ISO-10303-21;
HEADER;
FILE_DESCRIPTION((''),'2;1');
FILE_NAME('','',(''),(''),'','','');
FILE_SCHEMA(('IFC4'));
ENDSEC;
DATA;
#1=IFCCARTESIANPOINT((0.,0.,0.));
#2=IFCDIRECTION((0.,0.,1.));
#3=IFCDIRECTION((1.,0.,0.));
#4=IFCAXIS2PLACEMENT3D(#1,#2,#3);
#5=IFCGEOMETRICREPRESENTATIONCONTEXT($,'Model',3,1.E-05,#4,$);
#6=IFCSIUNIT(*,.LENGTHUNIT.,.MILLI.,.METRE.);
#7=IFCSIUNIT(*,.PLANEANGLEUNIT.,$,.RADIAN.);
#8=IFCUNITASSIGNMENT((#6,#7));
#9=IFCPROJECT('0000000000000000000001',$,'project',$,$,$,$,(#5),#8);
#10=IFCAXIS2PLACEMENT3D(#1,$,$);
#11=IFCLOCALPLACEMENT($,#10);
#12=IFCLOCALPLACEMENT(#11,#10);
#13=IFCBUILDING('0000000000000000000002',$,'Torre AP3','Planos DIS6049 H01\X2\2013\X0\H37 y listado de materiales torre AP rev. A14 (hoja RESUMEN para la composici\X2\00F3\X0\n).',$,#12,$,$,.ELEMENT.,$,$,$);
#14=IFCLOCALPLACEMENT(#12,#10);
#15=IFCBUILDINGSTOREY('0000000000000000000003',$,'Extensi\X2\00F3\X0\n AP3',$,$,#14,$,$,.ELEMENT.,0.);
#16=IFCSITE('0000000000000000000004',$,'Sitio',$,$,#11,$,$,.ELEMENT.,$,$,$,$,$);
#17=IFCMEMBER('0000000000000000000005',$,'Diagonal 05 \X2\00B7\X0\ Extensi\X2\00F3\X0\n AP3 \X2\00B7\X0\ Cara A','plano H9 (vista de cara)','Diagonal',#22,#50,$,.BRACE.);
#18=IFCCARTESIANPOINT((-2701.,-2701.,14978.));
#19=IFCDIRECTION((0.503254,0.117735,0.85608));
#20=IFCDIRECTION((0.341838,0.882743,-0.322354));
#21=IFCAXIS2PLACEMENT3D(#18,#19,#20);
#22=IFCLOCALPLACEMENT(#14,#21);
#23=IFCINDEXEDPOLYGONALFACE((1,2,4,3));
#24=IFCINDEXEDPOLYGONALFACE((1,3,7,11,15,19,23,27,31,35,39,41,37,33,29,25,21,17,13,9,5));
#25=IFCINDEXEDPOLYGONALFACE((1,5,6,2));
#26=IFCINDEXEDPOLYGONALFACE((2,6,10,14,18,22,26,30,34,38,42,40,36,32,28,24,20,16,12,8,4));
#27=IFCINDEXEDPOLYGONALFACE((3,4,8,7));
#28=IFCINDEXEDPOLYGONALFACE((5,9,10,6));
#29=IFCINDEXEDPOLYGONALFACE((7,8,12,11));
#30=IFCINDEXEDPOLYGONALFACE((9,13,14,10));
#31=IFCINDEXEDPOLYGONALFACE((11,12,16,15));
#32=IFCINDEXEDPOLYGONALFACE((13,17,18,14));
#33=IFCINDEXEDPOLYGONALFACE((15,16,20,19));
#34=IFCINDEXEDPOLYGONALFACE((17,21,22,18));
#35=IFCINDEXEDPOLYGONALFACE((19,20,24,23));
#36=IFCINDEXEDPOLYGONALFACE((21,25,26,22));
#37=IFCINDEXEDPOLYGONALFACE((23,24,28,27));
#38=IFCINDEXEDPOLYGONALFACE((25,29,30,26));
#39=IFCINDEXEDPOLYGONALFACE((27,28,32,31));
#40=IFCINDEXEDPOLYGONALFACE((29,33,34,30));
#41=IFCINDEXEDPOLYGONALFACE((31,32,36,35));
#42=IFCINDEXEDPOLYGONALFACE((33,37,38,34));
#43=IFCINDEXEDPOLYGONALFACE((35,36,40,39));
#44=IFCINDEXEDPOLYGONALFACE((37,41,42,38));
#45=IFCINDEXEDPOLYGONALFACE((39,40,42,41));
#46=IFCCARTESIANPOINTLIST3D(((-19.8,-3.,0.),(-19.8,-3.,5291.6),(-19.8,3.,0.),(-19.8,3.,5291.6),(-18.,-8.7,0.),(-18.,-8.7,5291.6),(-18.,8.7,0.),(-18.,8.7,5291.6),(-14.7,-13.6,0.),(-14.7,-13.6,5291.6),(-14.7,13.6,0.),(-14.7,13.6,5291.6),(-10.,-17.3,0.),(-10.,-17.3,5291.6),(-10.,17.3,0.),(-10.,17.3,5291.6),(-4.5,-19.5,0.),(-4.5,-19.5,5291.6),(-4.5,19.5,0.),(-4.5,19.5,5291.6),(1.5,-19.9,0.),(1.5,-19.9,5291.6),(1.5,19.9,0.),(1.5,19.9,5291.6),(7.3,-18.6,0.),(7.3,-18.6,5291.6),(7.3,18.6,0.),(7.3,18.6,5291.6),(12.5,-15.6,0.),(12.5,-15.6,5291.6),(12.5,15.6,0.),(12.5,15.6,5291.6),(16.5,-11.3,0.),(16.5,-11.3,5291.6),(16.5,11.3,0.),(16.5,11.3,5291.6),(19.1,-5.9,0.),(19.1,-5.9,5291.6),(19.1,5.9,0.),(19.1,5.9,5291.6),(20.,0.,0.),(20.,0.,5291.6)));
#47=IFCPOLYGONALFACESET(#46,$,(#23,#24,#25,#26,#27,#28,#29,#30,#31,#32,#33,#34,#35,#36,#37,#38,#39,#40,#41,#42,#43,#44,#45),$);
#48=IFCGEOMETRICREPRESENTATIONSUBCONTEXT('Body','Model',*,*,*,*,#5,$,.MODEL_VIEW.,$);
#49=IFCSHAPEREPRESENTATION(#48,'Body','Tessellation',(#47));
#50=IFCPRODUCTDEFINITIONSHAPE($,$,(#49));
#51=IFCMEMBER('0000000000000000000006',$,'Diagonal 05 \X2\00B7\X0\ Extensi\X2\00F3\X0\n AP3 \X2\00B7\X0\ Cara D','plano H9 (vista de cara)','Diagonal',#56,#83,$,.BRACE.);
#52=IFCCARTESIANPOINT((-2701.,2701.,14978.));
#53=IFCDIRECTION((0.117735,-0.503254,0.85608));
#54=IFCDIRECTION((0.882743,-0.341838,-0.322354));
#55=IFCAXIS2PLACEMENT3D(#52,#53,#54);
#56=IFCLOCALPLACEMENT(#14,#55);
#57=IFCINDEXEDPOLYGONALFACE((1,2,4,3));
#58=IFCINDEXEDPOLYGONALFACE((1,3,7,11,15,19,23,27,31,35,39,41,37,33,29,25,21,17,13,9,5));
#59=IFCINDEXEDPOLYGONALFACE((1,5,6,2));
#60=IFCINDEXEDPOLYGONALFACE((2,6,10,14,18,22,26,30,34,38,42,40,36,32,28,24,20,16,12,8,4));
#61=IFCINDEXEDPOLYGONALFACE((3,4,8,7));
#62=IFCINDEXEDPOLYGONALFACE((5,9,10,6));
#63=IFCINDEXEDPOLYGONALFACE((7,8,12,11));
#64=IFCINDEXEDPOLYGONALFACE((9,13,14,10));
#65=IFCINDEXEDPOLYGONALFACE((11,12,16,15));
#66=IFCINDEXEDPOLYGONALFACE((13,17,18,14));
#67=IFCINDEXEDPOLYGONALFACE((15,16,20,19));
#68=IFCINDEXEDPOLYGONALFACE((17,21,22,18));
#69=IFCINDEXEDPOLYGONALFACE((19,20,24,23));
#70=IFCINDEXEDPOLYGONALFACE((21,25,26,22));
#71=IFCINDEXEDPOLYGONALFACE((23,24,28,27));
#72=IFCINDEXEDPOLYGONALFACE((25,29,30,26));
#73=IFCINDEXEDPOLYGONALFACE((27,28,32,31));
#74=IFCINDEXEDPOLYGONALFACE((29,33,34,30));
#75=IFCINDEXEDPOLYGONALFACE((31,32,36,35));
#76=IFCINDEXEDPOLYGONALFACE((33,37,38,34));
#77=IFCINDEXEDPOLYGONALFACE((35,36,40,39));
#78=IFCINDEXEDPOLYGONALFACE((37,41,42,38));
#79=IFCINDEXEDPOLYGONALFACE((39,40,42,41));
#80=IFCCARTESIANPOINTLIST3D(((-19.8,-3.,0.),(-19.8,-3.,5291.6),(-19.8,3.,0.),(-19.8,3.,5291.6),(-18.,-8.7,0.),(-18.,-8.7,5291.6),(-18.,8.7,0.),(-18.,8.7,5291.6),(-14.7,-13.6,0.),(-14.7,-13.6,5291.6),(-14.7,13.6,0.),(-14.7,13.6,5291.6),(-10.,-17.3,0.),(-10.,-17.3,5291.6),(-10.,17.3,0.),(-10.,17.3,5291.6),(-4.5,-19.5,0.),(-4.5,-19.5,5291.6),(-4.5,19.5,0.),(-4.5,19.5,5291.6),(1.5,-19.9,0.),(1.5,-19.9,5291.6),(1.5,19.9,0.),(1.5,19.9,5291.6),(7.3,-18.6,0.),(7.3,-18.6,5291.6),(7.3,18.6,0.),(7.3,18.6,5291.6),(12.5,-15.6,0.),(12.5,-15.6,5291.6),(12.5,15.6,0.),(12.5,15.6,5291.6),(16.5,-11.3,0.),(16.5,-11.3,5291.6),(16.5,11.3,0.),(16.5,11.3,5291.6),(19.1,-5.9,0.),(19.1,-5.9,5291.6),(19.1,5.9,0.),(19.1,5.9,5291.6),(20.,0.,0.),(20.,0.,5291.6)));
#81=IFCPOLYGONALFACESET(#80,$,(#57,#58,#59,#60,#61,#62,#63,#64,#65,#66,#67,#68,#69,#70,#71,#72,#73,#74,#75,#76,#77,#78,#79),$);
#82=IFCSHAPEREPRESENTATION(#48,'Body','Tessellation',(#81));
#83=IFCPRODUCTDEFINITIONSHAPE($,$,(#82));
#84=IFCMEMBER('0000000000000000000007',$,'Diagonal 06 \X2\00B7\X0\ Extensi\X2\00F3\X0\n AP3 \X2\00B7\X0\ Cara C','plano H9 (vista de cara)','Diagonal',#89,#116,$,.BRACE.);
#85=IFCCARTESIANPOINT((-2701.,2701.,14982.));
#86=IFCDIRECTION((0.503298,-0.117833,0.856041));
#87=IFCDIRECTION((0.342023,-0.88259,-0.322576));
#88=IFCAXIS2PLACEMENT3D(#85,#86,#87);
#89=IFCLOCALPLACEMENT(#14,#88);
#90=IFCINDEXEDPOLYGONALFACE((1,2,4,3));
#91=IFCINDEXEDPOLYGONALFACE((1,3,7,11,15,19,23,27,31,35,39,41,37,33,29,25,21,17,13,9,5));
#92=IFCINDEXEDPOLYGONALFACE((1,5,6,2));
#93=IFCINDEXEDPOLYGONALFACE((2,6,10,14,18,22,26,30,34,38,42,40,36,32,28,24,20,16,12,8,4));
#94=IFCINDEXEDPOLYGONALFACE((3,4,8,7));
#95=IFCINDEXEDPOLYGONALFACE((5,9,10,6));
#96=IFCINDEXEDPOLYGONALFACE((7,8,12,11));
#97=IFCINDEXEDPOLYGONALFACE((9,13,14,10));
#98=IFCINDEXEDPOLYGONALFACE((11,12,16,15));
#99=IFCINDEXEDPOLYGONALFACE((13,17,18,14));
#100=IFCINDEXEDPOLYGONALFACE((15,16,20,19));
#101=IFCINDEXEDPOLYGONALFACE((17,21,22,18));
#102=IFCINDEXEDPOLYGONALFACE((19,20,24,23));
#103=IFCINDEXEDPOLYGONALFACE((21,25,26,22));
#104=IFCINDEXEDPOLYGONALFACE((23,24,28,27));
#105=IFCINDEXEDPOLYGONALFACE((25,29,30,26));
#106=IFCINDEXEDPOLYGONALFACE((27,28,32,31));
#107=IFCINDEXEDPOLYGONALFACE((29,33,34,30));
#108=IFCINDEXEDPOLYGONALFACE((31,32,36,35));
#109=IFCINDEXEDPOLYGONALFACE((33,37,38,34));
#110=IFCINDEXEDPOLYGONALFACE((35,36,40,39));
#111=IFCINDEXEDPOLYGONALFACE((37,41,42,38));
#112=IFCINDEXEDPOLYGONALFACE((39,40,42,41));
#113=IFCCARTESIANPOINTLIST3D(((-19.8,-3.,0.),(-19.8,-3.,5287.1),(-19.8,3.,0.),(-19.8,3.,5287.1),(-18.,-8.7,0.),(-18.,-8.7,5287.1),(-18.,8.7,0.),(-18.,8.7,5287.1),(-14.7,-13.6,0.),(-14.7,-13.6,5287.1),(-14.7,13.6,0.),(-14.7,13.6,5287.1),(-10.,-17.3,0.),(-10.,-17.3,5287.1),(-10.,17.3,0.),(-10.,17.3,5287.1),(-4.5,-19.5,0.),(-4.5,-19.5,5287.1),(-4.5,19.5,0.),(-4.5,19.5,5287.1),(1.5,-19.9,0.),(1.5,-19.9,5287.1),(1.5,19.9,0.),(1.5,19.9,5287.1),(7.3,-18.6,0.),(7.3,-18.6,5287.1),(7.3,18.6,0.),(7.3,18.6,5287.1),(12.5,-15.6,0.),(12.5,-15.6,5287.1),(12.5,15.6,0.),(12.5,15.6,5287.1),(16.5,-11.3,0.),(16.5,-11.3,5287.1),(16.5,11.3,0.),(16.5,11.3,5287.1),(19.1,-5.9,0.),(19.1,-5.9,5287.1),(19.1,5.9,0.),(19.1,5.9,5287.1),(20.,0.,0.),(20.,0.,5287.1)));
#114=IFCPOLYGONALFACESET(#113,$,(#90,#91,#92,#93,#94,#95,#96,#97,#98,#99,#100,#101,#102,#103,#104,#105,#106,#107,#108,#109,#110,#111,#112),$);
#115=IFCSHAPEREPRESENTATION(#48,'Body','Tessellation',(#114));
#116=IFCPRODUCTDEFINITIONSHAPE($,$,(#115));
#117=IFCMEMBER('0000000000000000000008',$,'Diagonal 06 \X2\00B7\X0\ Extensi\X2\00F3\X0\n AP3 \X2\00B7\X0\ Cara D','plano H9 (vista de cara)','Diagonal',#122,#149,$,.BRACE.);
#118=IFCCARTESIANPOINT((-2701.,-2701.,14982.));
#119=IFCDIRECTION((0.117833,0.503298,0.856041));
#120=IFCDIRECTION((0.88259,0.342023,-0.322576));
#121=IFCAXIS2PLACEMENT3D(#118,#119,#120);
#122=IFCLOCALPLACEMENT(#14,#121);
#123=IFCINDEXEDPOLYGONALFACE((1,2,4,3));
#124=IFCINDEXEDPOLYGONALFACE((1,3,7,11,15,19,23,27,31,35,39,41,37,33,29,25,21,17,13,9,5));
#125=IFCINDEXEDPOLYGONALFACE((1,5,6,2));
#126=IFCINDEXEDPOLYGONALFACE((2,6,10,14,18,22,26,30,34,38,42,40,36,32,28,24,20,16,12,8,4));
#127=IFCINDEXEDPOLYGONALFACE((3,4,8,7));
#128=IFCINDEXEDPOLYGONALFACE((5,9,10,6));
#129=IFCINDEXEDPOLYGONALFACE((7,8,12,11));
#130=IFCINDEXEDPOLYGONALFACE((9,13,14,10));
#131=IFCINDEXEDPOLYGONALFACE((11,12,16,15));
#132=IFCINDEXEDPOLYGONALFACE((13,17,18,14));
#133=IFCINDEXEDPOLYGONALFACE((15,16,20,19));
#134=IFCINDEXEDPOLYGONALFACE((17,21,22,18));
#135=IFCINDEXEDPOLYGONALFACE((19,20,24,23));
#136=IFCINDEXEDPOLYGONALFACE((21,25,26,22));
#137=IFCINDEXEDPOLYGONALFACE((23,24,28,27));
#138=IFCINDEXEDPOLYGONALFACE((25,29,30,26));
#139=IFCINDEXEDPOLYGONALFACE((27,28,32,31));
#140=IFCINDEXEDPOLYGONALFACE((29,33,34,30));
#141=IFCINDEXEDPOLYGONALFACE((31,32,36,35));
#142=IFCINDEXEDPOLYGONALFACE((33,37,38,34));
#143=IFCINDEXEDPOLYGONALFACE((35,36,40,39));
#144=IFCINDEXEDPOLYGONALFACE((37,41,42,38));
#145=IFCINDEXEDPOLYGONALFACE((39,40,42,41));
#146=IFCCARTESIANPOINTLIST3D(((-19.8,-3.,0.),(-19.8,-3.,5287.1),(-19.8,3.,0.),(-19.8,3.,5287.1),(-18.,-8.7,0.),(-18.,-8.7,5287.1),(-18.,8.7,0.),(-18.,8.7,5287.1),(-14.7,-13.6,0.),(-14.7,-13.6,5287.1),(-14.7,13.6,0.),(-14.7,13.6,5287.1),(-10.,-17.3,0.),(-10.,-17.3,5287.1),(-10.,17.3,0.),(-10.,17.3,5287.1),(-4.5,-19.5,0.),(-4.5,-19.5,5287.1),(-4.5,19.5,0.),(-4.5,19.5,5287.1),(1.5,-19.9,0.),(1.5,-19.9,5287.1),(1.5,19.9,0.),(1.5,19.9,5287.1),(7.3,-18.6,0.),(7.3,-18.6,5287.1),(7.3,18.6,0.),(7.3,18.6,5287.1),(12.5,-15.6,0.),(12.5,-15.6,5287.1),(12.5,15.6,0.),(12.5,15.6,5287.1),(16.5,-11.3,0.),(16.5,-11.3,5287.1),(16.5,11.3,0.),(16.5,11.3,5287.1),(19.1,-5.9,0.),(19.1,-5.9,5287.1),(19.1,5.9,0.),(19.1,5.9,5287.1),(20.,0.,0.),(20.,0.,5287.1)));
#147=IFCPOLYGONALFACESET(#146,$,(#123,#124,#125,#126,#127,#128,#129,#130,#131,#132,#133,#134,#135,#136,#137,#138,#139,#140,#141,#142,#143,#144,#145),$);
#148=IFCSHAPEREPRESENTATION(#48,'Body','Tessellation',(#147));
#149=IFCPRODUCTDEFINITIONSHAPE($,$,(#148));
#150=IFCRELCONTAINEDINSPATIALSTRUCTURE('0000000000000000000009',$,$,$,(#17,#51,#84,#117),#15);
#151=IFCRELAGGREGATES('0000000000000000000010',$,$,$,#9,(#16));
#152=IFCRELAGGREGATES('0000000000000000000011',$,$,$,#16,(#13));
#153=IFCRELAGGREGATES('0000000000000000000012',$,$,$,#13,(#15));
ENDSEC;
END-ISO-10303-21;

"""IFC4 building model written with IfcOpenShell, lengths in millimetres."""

from ifc_helpers import new_model, si_unit, frame, origin, origin_with_axes, place, context, subcontext, project, spatial, circle, extrude, element, save


model = new_model("IFC4")

# Units and contexts
model_context = context("Model", 3, precision=1e-05, world=origin_with_axes())
body_context = subcontext(model_context, "Body", "Model", "MODEL_VIEW")
ifc_project = project(units=[si_unit("LENGTHUNIT", "METRE", prefix="MILLI"), si_unit("PLANEANGLEUNIT", "RADIAN")], contexts=[model_context])

# Site, building, storey
site_placement = place(None, origin())
site = spatial("IfcSite", under=ifc_project, at=site_placement, Name="Sitio", CompositionType="ELEMENT")
building_placement = place(site_placement, origin())
building = spatial("IfcBuilding", under=site, at=building_placement, Name="Torre AP3", Description="Planos DIS6049 H01–H37 y listado de materiales torre AP rev. A14 (hoja RESUMEN para la composición).", CompositionType="ELEMENT")
storey_placement = place(building_placement, origin())
storey = spatial("IfcBuildingStorey", under=building, at=storey_placement, Name="Extensión AP3", CompositionType="ELEMENT", Elevation=0.0)

# Members
for number, where, z_axis, x_axis, name in (
    (1, (-2701.0, -2701.0, 14978.0), (0.503254, 0.117735, 0.85608), (0.341838, 0.882743, -0.322354), "Diagonal 05 · Extensión AP3 · Cara A"),
    (2, (-2701.0, 2701.0, 14978.0), (0.117735, -0.503254, 0.85608), (0.882743, -0.341838, -0.322354), "Diagonal 05 · Extensión AP3 · Cara D"),
):
    element("IfcMember", number, at=place(storey_placement, frame(where, z_axis=z_axis, x_axis=x_axis)), inside=storey, Name=name, Description="plano H9 (vista de cara)", ObjectType="Diagonal", PredefinedType="BRACE", context=body_context, shape_type="SweptSolid", body=[
        extrude(circle(Radius=20.0), None, (0.0, 0.0, 1.0), 5291.6),
    ])
for number, where, z_axis, x_axis, name in (
    (3, (-2701.0, 2701.0, 14982.0), (0.503298, -0.117833, 0.856041), (0.342023, -0.88259, -0.322576), "Diagonal 06 · Extensión AP3 · Cara C"),
    (4, (-2701.0, -2701.0, 14982.0), (0.117833, 0.503298, 0.856041), (0.88259, 0.342023, -0.322576), "Diagonal 06 · Extensión AP3 · Cara D"),
):
    element("IfcMember", number, at=place(storey_placement, frame(where, z_axis=z_axis, x_axis=x_axis)), inside=storey, Name=name, Description="plano H9 (vista de cara)", ObjectType="Diagonal", PredefinedType="BRACE", context=body_context, shape_type="SweptSolid", body=[
        extrude(circle(Radius=20.0), None, (0.0, 0.0, 1.0), 5287.1),
    ])

save(model, "model.ifc")
